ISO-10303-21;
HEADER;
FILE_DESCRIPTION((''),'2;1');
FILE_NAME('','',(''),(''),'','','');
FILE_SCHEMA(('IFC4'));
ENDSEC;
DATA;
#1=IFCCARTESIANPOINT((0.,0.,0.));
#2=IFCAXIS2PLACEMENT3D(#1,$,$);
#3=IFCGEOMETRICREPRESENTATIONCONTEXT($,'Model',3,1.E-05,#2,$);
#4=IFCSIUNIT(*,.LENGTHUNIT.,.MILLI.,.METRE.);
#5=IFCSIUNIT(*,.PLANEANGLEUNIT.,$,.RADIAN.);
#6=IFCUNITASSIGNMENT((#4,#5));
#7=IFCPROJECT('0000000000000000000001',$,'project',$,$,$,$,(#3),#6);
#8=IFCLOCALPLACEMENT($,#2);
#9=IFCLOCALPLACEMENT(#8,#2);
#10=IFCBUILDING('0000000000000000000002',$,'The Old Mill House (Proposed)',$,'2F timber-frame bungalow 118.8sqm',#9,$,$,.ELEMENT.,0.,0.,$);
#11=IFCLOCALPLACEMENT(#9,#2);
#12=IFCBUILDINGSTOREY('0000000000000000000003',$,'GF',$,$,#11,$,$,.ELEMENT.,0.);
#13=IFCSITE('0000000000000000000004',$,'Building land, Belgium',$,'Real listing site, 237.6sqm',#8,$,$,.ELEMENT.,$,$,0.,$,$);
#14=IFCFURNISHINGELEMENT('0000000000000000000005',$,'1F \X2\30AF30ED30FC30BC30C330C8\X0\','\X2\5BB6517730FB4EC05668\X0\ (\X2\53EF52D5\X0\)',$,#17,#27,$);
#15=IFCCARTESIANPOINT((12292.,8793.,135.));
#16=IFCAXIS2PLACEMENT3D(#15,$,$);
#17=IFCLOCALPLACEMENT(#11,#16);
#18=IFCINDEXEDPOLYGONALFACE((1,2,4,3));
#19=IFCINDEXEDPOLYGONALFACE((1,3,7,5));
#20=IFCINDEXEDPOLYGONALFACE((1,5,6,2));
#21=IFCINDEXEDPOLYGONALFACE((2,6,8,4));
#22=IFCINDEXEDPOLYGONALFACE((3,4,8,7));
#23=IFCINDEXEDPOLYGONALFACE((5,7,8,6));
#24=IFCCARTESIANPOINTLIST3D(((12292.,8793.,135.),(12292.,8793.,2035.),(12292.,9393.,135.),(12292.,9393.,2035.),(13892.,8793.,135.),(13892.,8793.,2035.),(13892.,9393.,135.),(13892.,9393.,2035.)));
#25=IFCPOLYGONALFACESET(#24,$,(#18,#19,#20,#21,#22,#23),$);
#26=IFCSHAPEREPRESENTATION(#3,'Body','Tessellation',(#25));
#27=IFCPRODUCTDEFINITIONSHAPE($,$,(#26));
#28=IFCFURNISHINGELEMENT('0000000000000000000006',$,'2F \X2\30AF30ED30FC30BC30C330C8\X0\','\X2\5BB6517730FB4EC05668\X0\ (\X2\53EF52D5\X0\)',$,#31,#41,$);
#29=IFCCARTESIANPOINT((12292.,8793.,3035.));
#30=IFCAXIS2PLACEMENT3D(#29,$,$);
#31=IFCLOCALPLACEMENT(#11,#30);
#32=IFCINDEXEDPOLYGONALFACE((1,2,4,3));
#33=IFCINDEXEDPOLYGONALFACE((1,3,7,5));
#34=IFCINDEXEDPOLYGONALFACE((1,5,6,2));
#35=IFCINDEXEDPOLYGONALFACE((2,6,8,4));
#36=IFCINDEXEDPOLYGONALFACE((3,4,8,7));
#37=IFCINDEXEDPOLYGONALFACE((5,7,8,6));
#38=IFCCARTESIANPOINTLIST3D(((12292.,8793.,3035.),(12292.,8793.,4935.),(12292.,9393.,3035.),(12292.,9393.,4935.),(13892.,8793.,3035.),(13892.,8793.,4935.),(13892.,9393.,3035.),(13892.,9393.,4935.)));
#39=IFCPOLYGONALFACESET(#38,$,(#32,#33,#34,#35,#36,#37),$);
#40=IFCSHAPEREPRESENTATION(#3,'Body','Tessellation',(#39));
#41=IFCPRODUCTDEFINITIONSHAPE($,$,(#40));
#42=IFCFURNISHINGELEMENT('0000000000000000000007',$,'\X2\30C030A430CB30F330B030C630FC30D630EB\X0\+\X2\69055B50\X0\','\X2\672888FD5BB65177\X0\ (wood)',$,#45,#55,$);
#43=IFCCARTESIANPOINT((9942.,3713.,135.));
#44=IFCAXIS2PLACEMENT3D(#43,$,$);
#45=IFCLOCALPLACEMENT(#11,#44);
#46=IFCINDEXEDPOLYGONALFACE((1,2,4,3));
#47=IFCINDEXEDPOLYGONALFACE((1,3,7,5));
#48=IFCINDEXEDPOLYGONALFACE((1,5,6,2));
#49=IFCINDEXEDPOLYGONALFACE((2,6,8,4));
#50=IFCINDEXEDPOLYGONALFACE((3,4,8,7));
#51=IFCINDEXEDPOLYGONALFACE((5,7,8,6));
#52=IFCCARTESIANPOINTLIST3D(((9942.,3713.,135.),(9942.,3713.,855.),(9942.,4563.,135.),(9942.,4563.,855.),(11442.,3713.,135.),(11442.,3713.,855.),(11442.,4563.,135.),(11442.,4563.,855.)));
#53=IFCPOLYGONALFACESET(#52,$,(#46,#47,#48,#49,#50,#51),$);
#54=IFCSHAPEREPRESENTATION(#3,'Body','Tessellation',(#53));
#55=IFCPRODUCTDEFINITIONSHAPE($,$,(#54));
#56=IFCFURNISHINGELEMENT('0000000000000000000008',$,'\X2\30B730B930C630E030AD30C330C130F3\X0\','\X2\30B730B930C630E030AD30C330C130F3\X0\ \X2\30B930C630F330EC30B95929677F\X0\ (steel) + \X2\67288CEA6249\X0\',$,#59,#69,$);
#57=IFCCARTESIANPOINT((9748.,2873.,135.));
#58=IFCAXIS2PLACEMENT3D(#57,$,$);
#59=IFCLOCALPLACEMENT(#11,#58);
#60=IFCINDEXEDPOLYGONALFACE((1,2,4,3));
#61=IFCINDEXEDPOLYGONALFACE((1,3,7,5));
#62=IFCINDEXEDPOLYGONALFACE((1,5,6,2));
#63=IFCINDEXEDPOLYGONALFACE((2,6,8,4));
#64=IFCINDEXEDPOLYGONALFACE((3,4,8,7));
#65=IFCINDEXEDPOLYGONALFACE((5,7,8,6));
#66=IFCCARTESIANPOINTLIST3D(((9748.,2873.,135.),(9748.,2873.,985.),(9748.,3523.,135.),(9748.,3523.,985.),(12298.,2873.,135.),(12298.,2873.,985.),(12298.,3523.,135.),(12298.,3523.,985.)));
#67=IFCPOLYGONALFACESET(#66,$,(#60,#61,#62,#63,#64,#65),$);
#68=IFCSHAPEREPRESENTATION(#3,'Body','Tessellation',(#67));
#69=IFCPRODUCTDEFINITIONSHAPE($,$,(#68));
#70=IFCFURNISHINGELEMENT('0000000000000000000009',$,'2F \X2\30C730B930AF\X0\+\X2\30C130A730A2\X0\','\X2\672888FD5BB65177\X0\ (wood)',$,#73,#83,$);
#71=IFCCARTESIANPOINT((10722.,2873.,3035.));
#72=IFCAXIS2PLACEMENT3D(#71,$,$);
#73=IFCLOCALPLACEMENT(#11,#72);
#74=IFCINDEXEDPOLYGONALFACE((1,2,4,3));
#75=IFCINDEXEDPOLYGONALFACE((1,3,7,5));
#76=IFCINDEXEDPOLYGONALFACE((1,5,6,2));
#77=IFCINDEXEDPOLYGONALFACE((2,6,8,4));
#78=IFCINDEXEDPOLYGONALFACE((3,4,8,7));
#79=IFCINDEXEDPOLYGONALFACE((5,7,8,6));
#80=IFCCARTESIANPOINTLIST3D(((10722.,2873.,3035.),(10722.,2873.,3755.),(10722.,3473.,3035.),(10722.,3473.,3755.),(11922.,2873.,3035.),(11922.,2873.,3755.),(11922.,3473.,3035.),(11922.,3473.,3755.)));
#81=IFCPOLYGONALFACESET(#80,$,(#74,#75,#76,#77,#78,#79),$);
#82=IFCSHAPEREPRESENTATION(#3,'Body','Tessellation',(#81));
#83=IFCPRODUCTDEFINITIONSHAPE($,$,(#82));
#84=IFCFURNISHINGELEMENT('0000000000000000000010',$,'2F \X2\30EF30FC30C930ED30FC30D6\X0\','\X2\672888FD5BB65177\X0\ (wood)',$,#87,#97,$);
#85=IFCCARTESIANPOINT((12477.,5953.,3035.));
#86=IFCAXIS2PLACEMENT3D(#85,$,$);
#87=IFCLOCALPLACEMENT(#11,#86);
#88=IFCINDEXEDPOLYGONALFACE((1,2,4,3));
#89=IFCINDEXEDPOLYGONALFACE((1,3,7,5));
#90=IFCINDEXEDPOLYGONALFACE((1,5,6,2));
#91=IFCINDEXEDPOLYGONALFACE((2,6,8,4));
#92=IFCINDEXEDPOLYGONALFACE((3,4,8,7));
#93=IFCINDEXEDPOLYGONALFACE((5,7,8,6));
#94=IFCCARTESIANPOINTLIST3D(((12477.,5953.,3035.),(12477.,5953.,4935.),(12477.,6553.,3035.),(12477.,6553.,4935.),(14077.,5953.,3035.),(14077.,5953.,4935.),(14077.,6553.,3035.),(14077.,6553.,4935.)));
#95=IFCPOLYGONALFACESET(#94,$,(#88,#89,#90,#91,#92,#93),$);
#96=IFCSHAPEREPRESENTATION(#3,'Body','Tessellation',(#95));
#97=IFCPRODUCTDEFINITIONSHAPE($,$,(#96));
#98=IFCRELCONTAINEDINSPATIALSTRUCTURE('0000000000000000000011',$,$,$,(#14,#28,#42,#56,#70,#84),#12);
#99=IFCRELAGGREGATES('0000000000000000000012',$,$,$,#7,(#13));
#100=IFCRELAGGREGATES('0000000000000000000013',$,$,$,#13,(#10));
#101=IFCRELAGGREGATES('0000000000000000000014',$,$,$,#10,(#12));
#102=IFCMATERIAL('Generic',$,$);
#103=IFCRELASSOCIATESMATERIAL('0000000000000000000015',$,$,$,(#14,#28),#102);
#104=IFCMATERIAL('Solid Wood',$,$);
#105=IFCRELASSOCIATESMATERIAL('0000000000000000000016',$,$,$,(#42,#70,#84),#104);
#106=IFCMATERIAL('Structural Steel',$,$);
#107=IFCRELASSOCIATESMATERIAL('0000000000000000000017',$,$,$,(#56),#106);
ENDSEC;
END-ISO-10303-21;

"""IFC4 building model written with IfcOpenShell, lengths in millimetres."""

from ifc_helpers import new_model, si_unit, frame, frame_2d, origin, place, context, project, spatial, rectangle, extrude, material, element, save


model = new_model("IFC4")

# Units and contexts
model_context = context("Model", 3, precision=1e-05, world=origin())
ifc_project = project(units=[si_unit("LENGTHUNIT", "METRE", prefix="MILLI"), si_unit("PLANEANGLEUNIT", "RADIAN")], contexts=[model_context])

# Site, building, storey
site_placement = place(None, origin())
site = spatial("IfcSite", under=ifc_project, at=site_placement, Name="Building land, Belgium", ObjectType="Real listing site, 237.6sqm", CompositionType="ELEMENT", RefElevation=0.0)
building_placement = place(site_placement, origin())
building = spatial("IfcBuilding", under=site, at=building_placement, Name="The Old Mill House (Proposed)", ObjectType="2F timber-frame bungalow 118.8sqm", CompositionType="ELEMENT", ElevationOfRefHeight=0.0, ElevationOfTerrain=0.0)
storey_placement = place(building_placement, origin())
storey = spatial("IfcBuildingStorey", under=building, at=storey_placement, Name="GF", CompositionType="ELEMENT", Elevation=0.0)

# Shared definitions
ifc_material_1 = material(Name="Solid Wood")

# Shared definitions
ifc_material_2 = material(Name="Generic")

# Furnishing elements
furnishing_1_placement = place(storey_placement, frame((12292.0, 8793.0, 135.0)))
element("IfcFurnishingElement", 1, at=furnishing_1_placement, inside=storey, material=ifc_material_2, Name="1F クローゼット", Description="家具・什器 (可動)", context=model_context, shape_type="SweptSolid", body=[
    extrude(rectangle(XDim=1600.0, YDim=600.0, at=frame_2d((800.0, 300.0))), frame((12292.0, 8793.0, 135.0)), (0.0, 0.0, 1.0), 1900.0),
])
furnishing_2_placement = place(storey_placement, frame((12292.0, 8793.0, 3035.0)))
element("IfcFurnishingElement", 2, at=furnishing_2_placement, inside=storey, material=ifc_material_2, Name="2F クローゼット", Description="家具・什器 (可動)", context=model_context, shape_type="SweptSolid", body=[
    extrude(rectangle(XDim=1600.0, YDim=600.0, at=frame_2d((800.0, 300.0))), frame((12292.0, 8793.0, 3035.0)), (0.0, 0.0, 1.0), 1900.0),
])
furnishing_3_placement = place(storey_placement, frame((9942.0, 3713.0, 135.0)))
element("IfcFurnishingElement", 3, at=furnishing_3_placement, inside=storey, material=ifc_material_1, Name="ダイニングテーブル+椅子", Description="木製家具 (wood)", context=model_context, shape_type="SweptSolid", body=[
    extrude(rectangle(XDim=1500.0, YDim=850.0, at=frame_2d((750.0, 425.0))), frame((9942.0, 3713.0, 135.0)), (0.0, 0.0, 1.0), 720.0),
])
ifc_material_3 = material(Name="Structural Steel")
furnishing_4_placement = place(storey_placement, frame((9748.0, 2873.0, 135.0)))
element("IfcFurnishingElement", 4, at=furnishing_4_placement, inside=storey, material=ifc_material_3, Name="システムキッチン", Description="システムキッチン ステンレス天板 (steel) + 木質扉", context=model_context, shape_type="SweptSolid", body=[
    extrude(rectangle(XDim=2550.0, YDim=650.0, at=frame_2d((1275.0, 325.0))), frame((9748.0, 2873.0, 135.0)), (0.0, 0.0, 1.0), 850.0),
])
furnishing_5_placement = place(storey_placement, frame((10722.0, 2873.0, 3035.0)))
element("IfcFurnishingElement", 5, at=furnishing_5_placement, inside=storey, material=ifc_material_1, Name="2F デスク+チェア", Description="木製家具 (wood)", context=model_context, shape_type="SweptSolid", body=[
    extrude(rectangle(XDim=1200.0, YDim=600.0, at=frame_2d((600.0, 300.0))), frame((10722.0, 2873.0, 3035.0)), (0.0, 0.0, 1.0), 720.0),
])
furnishing_6_placement = place(storey_placement, frame((12477.0, 5953.0, 3035.0)))
element("IfcFurnishingElement", 6, at=furnishing_6_placement, inside=storey, material=ifc_material_1, Name="2F ワードローブ", Description="木製家具 (wood)", context=model_context, shape_type="SweptSolid", body=[
    extrude(rectangle(XDim=1600.0, YDim=600.0, at=frame_2d((800.0, 300.0))), frame((12477.0, 5953.0, 3035.0)), (0.0, 0.0, 1.0), 1900.0),
])

save(model, "model.ifc")
